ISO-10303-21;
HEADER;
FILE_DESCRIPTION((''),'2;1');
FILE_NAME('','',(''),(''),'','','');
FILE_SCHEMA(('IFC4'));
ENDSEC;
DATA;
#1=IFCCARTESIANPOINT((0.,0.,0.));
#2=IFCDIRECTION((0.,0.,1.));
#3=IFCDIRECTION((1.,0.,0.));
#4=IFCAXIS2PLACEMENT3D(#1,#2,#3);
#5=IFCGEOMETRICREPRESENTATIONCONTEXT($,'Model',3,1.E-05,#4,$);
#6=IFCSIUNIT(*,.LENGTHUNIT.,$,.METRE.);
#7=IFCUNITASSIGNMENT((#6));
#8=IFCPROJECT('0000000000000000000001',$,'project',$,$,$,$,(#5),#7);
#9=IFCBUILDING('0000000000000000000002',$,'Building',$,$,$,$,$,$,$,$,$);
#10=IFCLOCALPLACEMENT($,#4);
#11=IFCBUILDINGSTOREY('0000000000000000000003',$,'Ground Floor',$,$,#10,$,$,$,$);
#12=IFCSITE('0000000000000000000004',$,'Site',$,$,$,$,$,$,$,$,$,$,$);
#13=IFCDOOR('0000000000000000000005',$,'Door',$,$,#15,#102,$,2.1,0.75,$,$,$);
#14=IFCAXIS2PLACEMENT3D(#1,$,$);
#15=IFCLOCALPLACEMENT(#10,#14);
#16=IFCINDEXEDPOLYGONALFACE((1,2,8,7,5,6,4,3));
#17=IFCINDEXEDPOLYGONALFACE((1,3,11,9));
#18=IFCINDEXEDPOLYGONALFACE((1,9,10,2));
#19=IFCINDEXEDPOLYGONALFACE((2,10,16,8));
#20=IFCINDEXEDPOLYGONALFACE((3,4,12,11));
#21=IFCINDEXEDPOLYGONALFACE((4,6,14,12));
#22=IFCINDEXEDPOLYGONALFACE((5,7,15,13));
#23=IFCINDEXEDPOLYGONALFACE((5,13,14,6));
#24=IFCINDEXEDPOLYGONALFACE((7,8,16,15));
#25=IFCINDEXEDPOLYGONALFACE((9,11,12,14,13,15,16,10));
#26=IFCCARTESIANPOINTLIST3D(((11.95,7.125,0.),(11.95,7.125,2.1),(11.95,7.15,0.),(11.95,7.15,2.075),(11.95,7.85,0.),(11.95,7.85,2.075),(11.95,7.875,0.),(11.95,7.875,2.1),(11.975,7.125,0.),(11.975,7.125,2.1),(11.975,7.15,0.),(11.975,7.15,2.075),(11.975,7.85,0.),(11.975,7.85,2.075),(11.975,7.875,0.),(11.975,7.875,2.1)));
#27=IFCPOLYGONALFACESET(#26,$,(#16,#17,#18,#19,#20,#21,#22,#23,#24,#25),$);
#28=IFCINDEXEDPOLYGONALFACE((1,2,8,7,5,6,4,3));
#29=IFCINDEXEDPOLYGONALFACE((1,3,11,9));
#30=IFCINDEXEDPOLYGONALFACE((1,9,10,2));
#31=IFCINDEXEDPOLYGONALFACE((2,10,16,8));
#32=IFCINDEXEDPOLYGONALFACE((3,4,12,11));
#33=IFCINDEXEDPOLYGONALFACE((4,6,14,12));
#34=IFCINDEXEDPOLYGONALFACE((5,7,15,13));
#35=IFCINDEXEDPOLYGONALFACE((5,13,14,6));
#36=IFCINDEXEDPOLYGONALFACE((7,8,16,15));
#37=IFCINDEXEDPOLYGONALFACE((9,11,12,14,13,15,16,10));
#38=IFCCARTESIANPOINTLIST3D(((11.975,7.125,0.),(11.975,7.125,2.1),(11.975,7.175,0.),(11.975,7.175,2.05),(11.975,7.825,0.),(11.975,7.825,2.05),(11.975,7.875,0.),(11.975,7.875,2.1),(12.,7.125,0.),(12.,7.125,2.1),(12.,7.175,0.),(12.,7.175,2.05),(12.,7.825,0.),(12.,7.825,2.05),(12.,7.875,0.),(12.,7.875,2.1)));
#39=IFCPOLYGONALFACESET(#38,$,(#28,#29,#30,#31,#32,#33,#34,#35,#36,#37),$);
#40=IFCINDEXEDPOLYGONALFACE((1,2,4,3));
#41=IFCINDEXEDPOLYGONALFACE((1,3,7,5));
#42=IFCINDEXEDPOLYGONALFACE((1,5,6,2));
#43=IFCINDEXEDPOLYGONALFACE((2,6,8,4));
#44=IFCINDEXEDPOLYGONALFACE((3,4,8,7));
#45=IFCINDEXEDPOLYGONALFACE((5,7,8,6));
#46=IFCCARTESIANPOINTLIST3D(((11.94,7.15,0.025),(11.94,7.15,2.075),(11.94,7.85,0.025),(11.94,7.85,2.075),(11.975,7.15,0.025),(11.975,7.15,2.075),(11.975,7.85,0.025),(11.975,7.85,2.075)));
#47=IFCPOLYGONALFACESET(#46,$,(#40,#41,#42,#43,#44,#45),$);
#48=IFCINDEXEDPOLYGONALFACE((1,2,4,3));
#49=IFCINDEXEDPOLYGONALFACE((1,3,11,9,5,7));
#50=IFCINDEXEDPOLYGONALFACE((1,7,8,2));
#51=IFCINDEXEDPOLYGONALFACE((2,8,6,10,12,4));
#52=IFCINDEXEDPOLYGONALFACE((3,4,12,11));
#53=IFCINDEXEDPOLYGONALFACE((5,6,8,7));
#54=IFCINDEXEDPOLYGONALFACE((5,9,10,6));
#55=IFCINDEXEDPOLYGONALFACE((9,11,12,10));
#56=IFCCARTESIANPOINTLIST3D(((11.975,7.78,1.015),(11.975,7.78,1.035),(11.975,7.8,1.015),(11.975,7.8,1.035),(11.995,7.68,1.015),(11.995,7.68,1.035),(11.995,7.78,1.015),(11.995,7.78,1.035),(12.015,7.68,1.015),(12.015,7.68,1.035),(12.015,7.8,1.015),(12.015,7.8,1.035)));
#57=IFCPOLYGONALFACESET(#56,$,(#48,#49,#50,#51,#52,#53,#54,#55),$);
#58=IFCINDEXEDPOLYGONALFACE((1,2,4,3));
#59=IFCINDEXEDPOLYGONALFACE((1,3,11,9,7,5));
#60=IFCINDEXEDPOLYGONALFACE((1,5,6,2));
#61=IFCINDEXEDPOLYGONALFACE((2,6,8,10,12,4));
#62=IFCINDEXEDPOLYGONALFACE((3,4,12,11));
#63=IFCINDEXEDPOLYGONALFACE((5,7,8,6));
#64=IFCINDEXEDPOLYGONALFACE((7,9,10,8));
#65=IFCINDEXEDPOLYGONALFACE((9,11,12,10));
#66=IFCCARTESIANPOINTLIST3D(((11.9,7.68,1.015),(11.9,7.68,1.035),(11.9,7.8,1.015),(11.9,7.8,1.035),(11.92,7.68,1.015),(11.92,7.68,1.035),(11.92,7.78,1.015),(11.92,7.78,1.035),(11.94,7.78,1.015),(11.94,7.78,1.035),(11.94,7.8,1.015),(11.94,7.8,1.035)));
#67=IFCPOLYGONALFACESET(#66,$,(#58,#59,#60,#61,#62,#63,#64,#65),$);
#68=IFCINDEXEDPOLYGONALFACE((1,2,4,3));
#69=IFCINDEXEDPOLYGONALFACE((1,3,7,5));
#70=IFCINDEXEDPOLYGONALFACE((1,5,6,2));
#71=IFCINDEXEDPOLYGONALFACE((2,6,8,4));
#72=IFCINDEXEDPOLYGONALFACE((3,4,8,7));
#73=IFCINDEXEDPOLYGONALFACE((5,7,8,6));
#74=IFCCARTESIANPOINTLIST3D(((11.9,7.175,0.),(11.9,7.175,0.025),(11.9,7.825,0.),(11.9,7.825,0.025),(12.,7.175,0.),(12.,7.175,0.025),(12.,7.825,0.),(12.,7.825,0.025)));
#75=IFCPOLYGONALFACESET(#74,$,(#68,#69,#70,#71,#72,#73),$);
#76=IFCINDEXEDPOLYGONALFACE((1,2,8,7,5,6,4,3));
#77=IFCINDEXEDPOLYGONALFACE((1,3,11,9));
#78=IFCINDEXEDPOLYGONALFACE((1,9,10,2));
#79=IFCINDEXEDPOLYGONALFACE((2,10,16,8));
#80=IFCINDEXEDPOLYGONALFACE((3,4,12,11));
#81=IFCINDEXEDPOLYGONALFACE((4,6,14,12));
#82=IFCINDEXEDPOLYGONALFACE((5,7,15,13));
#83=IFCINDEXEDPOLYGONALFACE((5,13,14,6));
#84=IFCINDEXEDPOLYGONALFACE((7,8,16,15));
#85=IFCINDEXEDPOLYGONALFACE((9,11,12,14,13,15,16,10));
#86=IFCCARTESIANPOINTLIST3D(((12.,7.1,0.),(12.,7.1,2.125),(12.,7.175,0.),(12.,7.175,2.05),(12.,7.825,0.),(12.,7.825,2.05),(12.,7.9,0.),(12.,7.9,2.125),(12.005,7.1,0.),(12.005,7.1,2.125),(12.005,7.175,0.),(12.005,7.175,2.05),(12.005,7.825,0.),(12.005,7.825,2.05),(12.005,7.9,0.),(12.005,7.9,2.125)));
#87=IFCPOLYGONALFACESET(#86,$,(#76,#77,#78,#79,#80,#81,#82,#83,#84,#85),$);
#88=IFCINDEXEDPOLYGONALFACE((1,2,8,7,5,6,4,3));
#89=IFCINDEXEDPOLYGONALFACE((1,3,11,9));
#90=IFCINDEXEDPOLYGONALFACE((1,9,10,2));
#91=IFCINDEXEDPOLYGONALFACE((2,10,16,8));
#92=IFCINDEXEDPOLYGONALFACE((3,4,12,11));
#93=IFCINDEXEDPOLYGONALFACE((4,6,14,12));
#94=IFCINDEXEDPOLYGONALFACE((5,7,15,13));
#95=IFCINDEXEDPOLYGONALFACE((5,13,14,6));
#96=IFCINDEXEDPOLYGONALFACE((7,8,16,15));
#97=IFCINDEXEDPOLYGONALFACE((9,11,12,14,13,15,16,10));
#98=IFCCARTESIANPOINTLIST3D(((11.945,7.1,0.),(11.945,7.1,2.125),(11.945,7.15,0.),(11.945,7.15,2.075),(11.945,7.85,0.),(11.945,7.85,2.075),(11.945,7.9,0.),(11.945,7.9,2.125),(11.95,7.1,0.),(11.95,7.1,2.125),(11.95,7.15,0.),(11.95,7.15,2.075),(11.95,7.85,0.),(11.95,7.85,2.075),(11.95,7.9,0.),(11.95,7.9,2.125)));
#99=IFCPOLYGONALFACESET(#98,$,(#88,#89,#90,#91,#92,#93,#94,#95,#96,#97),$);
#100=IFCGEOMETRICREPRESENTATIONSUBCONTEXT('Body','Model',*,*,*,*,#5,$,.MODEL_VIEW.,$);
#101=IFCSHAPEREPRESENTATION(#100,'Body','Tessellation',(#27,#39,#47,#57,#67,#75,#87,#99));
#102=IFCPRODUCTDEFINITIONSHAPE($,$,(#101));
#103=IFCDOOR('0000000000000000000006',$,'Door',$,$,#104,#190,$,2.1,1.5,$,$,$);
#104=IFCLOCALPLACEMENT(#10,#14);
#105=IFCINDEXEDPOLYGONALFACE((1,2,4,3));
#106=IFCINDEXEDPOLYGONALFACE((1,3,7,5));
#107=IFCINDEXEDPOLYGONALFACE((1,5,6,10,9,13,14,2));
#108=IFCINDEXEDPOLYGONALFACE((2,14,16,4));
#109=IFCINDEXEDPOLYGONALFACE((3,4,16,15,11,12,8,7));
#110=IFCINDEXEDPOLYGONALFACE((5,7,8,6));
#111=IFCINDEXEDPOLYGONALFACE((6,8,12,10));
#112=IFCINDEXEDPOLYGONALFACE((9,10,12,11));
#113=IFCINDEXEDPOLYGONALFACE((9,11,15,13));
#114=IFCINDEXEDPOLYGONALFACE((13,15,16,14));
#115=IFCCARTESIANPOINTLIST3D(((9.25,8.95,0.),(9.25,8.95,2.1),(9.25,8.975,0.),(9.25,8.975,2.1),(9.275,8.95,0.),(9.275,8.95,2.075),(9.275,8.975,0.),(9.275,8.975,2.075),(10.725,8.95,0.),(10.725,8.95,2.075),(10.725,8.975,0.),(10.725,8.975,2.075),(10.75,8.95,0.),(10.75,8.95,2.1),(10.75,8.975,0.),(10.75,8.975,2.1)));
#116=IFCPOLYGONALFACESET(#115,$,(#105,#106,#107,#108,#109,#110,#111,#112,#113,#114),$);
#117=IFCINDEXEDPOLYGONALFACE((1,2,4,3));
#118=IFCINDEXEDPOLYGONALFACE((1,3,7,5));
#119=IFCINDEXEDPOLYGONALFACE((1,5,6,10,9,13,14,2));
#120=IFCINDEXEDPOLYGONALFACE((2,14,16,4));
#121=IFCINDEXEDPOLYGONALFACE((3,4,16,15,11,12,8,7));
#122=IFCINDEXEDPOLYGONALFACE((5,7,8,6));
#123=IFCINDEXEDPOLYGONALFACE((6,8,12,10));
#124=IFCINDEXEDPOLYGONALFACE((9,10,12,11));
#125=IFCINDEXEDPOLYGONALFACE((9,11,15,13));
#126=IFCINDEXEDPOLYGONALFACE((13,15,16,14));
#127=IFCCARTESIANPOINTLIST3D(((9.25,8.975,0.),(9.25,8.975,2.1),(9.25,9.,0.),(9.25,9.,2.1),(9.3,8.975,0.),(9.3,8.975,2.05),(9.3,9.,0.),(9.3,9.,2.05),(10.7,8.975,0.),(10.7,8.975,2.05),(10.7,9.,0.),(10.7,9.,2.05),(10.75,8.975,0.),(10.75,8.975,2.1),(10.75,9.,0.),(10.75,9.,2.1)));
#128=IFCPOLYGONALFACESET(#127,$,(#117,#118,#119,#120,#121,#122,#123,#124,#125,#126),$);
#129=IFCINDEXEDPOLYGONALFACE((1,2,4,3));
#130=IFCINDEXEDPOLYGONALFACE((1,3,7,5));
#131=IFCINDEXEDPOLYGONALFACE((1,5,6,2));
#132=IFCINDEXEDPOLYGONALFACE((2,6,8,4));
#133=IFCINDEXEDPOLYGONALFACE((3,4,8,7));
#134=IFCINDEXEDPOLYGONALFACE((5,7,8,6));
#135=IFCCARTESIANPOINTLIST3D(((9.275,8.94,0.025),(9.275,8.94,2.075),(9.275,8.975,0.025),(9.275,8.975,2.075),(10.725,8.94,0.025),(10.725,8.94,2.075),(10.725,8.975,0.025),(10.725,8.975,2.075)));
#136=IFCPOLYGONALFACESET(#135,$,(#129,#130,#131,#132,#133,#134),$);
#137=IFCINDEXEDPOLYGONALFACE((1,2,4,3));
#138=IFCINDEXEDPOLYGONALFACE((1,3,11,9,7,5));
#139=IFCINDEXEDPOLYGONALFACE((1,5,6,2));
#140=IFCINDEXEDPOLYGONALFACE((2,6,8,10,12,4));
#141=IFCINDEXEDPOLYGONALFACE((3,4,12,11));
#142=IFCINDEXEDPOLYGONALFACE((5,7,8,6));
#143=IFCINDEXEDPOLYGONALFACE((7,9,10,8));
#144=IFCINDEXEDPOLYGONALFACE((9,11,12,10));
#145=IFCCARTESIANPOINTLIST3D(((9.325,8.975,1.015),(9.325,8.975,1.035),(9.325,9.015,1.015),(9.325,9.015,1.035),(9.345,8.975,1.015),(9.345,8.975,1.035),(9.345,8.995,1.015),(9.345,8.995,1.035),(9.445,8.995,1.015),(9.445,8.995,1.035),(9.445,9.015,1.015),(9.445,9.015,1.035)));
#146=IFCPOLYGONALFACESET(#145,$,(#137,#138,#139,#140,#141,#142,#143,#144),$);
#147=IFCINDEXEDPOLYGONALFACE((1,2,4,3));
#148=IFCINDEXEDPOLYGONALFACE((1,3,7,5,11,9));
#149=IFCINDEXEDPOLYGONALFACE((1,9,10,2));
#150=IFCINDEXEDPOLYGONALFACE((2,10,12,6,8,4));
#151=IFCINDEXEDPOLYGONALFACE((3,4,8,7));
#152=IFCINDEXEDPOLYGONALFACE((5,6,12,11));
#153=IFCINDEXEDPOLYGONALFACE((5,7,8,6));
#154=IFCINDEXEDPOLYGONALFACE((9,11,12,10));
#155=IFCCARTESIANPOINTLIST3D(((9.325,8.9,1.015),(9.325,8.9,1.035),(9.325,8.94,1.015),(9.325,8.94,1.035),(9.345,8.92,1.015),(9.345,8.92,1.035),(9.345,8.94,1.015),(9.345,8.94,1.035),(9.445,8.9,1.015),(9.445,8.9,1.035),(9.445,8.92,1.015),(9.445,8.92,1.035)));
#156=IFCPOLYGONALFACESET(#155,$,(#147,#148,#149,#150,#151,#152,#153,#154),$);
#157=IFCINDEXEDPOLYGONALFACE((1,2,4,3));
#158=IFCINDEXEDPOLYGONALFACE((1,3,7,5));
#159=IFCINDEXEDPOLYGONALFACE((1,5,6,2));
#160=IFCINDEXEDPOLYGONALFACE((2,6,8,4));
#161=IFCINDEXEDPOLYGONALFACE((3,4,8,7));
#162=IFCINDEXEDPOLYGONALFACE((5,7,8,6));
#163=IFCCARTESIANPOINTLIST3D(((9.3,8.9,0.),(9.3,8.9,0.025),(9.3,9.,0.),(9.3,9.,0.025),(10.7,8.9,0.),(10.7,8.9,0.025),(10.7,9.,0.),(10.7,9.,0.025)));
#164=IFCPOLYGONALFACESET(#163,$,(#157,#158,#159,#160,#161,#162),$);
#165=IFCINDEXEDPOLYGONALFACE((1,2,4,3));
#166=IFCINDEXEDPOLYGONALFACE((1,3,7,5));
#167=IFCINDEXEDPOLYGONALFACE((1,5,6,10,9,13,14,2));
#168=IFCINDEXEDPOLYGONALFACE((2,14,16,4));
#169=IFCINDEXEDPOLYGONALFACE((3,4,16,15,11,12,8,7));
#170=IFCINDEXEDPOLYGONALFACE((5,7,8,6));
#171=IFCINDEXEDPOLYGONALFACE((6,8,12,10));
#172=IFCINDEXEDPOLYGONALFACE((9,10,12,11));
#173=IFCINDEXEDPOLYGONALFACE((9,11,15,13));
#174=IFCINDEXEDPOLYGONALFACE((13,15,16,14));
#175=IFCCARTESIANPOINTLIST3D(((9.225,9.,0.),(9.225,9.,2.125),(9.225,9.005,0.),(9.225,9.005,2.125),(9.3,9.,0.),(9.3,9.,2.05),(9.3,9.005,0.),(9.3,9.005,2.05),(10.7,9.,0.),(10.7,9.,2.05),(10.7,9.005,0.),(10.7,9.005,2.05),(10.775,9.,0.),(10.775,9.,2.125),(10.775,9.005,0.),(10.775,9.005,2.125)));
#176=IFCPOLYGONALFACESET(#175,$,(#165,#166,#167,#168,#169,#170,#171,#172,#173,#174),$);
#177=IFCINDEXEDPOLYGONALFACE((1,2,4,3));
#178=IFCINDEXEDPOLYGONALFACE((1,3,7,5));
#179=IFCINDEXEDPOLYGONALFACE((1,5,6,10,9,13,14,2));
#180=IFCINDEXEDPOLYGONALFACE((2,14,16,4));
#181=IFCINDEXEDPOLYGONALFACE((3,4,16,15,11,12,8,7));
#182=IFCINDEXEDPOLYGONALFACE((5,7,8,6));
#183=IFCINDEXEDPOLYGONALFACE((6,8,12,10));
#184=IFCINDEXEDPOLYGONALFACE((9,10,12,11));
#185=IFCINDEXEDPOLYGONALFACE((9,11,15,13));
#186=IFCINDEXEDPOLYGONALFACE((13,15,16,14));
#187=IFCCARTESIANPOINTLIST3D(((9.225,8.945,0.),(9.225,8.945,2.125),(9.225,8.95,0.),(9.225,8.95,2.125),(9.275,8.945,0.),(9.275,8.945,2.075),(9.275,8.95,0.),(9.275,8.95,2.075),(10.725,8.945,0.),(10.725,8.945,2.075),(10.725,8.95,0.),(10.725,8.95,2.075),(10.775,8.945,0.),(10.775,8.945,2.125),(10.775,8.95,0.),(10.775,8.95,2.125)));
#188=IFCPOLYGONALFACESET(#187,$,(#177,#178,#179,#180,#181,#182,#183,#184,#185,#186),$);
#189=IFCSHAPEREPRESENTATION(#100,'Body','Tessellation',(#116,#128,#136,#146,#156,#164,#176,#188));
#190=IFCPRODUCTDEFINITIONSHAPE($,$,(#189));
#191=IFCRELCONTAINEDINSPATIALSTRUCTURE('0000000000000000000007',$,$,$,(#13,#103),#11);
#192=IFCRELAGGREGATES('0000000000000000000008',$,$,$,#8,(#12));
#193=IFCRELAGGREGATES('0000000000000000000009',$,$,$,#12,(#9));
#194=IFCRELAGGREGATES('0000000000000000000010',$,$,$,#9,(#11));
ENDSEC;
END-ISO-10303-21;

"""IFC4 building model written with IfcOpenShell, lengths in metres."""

from ifc_helpers import new_model, si_unit, frame, origin_with_axes, place, context, subcontext, project, spatial, line, indexed_curve, outline, extrude, element, save


model = new_model("IFC4")

# Units and contexts
model_context = context("Model", 3, precision=1e-05, world=origin_with_axes())
body_context = subcontext(model_context, "Body", "Model", "MODEL_VIEW")
ifc_project = project(units=[si_unit("LENGTHUNIT", "METRE")], contexts=[model_context])

# Site, building, storey
site = spatial("IfcSite", under=ifc_project, Name="Site")
building = spatial("IfcBuilding", under=site, Name="Building")
storey_placement = place(None, origin_with_axes())
storey = spatial("IfcBuildingStorey", under=building, at=storey_placement, Name="Ground Floor")

# Doors
door_1_placement = place(storey_placement, frame((12.0, 7.125, 0.0), z_axis=(0.0, 0.0, 1.0), x_axis=(0.0, 1.0, 0.0)))
element("IfcDoor", 1, at=door_1_placement, inside=storey, Name="Door", OverallHeight=2.1, OverallWidth=0.75, context=body_context, shape_type="SweptSolid", body=[
    extrude(outline(indexed_curve([(0.0, 0.0), (0.0, 2.1), (0.75, 2.1), (0.75, 0.0), (0.725, 0.0), (0.725, 2.075), (0.025, 2.075), (0.025, 0.0)], segments=[line(1, 2, 3, 4, 5, 6, 7, 8, 1)])), frame((0.0, 0.025, 0.0), z_axis=(0.0, -1.0, 0.0), x_axis=(1.0, 0.0, 0.0)), (0.0, 0.0, -1.0), 0.025),
    extrude(outline(indexed_curve([(0.0, 0.0), (0.0, 2.1), (0.75, 2.1), (0.75, 0.0), (0.7, 0.0), (0.7, 2.05), (0.05, 2.05), (0.05, 0.0)], segments=[line(1, 2, 3, 4, 5, 6, 7, 8, 1)])), frame((0.0, 0.0, 0.0), z_axis=(0.0, -1.0, 0.0), x_axis=(1.0, 0.0, 0.0)), (0.0, 0.0, -1.0), 0.025),
    extrude(outline(indexed_curve([(0.0, 0.0), (0.7, 0.0), (0.7, 0.035), (0.0, 0.035)], segments=[line(1, 2, 3, 4, 1)])), frame((0.025, 0.025, 0.025), z_axis=(0.0, 0.0, 1.0), x_axis=(1.0, 0.0, 0.0)), (0.0, 0.0, 1.0), 2.05),
    extrude(outline(indexed_curve([(0.0, 0.0), (0.0, -0.04), (-0.12, -0.04), (-0.12, -0.02), (-0.02, -0.02), (-0.02, 0.0)], segments=[line(1, 2, 3, 4, 5, 6, 1)])), frame((0.675, 0.025, 1.015), z_axis=(0.0, 0.0, 1.0), x_axis=(1.0, 0.0, 0.0)), (0.0, 0.0, 1.0), 0.02),
    extrude(outline(indexed_curve([(0.0, 0.0), (0.0, 0.04), (-0.12, 0.04), (-0.12, 0.02), (-0.02, 0.02), (-0.02, 0.0)], segments=[line(1, 2, 3, 4, 5, 6, 1)])), frame((0.675, 0.06, 1.015), z_axis=(0.0, 0.0, 1.0), x_axis=(1.0, 0.0, 0.0)), (0.0, 0.0, 1.0), 0.02),
    extrude(outline(indexed_curve([(0.0, 0.0), (0.65, 0.0), (0.65, 0.1), (0.0, 0.1)], segments=[line(1, 2, 3, 4, 1)])), frame((0.05, 0.0, 0.0), z_axis=(0.0, 0.0, 1.0), x_axis=(1.0, 0.0, 0.0)), (0.0, 0.0, 1.0), 0.025),
    extrude(outline(indexed_curve([(0.0, 0.0), (0.0, 2.125), (0.8, 2.125), (0.8, 0.0), (0.725, 0.0), (0.725, 2.05), (0.075, 2.05), (0.075, 0.0)], segments=[line(1, 2, 3, 4, 5, 6, 7, 8, 1)])), frame((-0.025, -0.005, 0.0), z_axis=(0.0, -1.0, 0.0), x_axis=(1.0, 0.0, 0.0)), (0.0, 0.0, -1.0), 0.005),
    extrude(outline(indexed_curve([(0.0, 0.0), (0.0, 2.125), (0.8, 2.125), (0.8, 0.0), (0.75, 0.0), (0.75, 2.075), (0.05, 2.075), (0.05, 0.0)], segments=[line(1, 2, 3, 4, 5, 6, 7, 8, 1)])), frame((-0.025, 0.05, 0.0), z_axis=(0.0, -1.0, 0.0), x_axis=(1.0, 0.0, 0.0)), (0.0, 0.0, -1.0), 0.005),
])
door_2_placement = place(storey_placement, frame((10.75, 9.0, 0.0), z_axis=(0.0, 0.0, 1.0), x_axis=(-1.0, 0.0, 0.0)))
element("IfcDoor", 2, at=door_2_placement, inside=storey, Name="Door", OverallHeight=2.1, OverallWidth=1.5, context=body_context, shape_type="SweptSolid", body=[
    extrude(outline(indexed_curve([(0.0, 0.0), (0.0, 2.1), (1.5, 2.1), (1.5, 0.0), (1.475, 0.0), (1.475, 2.075), (0.025, 2.075), (0.025, 0.0)], segments=[line(1, 2, 3, 4, 5, 6, 7, 8, 1)])), frame((0.0, 0.025, 0.0), z_axis=(0.0, -1.0, 0.0), x_axis=(1.0, 0.0, 0.0)), (0.0, 0.0, -1.0), 0.025),
    extrude(outline(indexed_curve([(0.0, 0.0), (0.0, 2.1), (1.5, 2.1), (1.5, 0.0), (1.45, 0.0), (1.45, 2.05), (0.05, 2.05), (0.05, 0.0)], segments=[line(1, 2, 3, 4, 5, 6, 7, 8, 1)])), frame((0.0, 0.0, 0.0), z_axis=(0.0, -1.0, 0.0), x_axis=(1.0, 0.0, 0.0)), (0.0, 0.0, -1.0), 0.025),
    extrude(outline(indexed_curve([(0.0, 0.0), (1.45, 0.0), (1.45, 0.035), (0.0, 0.035)], segments=[line(1, 2, 3, 4, 1)])), frame((0.025, 0.025, 0.025), z_axis=(0.0, 0.0, 1.0), x_axis=(1.0, 0.0, 0.0)), (0.0, 0.0, 1.0), 2.05),
    extrude(outline(indexed_curve([(0.0, 0.0), (0.0, -0.04), (-0.12, -0.04), (-0.12, -0.02), (-0.02, -0.02), (-0.02, 0.0)], segments=[line(1, 2, 3, 4, 5, 6, 1)])), frame((1.425, 0.025, 1.015), z_axis=(0.0, 0.0, 1.0), x_axis=(1.0, 0.0, 0.0)), (0.0, 0.0, 1.0), 0.02),
    extrude(outline(indexed_curve([(0.0, 0.0), (0.0, 0.04), (-0.12, 0.04), (-0.12, 0.02), (-0.02, 0.02), (-0.02, 0.0)], segments=[line(1, 2, 3, 4, 5, 6, 1)])), frame((1.425, 0.06, 1.015), z_axis=(0.0, 0.0, 1.0), x_axis=(1.0, 0.0, 0.0)), (0.0, 0.0, 1.0), 0.02),
    extrude(outline(indexed_curve([(0.0, 0.0), (1.4, 0.0), (1.4, 0.1), (0.0, 0.1)], segments=[line(1, 2, 3, 4, 1)])), frame((0.05, 0.0, 0.0), z_axis=(0.0, 0.0, 1.0), x_axis=(1.0, 0.0, 0.0)), (0.0, 0.0, 1.0), 0.025),
    extrude(outline(indexed_curve([(0.0, 0.0), (0.0, 2.125), (1.55, 2.125), (1.55, 0.0), (1.475, 0.0), (1.475, 2.05), (0.075, 2.05), (0.075, 0.0)], segments=[line(1, 2, 3, 4, 5, 6, 7, 8, 1)])), frame((-0.025, -0.005, 0.0), z_axis=(0.0, -1.0, 0.0), x_axis=(1.0, 0.0, 0.0)), (0.0, 0.0, -1.0), 0.005),
    extrude(outline(indexed_curve([(0.0, 0.0), (0.0, 2.125), (1.55, 2.125), (1.55, 0.0), (1.5, 0.0), (1.5, 2.075), (0.05, 2.075), (0.05, 0.0)], segments=[line(1, 2, 3, 4, 5, 6, 7, 8, 1)])), frame((-0.025, 0.05, 0.0), z_axis=(0.0, -1.0, 0.0), x_axis=(1.0, 0.0, 0.0)), (0.0, 0.0, -1.0), 0.005),
])

save(model, "model.ifc")
